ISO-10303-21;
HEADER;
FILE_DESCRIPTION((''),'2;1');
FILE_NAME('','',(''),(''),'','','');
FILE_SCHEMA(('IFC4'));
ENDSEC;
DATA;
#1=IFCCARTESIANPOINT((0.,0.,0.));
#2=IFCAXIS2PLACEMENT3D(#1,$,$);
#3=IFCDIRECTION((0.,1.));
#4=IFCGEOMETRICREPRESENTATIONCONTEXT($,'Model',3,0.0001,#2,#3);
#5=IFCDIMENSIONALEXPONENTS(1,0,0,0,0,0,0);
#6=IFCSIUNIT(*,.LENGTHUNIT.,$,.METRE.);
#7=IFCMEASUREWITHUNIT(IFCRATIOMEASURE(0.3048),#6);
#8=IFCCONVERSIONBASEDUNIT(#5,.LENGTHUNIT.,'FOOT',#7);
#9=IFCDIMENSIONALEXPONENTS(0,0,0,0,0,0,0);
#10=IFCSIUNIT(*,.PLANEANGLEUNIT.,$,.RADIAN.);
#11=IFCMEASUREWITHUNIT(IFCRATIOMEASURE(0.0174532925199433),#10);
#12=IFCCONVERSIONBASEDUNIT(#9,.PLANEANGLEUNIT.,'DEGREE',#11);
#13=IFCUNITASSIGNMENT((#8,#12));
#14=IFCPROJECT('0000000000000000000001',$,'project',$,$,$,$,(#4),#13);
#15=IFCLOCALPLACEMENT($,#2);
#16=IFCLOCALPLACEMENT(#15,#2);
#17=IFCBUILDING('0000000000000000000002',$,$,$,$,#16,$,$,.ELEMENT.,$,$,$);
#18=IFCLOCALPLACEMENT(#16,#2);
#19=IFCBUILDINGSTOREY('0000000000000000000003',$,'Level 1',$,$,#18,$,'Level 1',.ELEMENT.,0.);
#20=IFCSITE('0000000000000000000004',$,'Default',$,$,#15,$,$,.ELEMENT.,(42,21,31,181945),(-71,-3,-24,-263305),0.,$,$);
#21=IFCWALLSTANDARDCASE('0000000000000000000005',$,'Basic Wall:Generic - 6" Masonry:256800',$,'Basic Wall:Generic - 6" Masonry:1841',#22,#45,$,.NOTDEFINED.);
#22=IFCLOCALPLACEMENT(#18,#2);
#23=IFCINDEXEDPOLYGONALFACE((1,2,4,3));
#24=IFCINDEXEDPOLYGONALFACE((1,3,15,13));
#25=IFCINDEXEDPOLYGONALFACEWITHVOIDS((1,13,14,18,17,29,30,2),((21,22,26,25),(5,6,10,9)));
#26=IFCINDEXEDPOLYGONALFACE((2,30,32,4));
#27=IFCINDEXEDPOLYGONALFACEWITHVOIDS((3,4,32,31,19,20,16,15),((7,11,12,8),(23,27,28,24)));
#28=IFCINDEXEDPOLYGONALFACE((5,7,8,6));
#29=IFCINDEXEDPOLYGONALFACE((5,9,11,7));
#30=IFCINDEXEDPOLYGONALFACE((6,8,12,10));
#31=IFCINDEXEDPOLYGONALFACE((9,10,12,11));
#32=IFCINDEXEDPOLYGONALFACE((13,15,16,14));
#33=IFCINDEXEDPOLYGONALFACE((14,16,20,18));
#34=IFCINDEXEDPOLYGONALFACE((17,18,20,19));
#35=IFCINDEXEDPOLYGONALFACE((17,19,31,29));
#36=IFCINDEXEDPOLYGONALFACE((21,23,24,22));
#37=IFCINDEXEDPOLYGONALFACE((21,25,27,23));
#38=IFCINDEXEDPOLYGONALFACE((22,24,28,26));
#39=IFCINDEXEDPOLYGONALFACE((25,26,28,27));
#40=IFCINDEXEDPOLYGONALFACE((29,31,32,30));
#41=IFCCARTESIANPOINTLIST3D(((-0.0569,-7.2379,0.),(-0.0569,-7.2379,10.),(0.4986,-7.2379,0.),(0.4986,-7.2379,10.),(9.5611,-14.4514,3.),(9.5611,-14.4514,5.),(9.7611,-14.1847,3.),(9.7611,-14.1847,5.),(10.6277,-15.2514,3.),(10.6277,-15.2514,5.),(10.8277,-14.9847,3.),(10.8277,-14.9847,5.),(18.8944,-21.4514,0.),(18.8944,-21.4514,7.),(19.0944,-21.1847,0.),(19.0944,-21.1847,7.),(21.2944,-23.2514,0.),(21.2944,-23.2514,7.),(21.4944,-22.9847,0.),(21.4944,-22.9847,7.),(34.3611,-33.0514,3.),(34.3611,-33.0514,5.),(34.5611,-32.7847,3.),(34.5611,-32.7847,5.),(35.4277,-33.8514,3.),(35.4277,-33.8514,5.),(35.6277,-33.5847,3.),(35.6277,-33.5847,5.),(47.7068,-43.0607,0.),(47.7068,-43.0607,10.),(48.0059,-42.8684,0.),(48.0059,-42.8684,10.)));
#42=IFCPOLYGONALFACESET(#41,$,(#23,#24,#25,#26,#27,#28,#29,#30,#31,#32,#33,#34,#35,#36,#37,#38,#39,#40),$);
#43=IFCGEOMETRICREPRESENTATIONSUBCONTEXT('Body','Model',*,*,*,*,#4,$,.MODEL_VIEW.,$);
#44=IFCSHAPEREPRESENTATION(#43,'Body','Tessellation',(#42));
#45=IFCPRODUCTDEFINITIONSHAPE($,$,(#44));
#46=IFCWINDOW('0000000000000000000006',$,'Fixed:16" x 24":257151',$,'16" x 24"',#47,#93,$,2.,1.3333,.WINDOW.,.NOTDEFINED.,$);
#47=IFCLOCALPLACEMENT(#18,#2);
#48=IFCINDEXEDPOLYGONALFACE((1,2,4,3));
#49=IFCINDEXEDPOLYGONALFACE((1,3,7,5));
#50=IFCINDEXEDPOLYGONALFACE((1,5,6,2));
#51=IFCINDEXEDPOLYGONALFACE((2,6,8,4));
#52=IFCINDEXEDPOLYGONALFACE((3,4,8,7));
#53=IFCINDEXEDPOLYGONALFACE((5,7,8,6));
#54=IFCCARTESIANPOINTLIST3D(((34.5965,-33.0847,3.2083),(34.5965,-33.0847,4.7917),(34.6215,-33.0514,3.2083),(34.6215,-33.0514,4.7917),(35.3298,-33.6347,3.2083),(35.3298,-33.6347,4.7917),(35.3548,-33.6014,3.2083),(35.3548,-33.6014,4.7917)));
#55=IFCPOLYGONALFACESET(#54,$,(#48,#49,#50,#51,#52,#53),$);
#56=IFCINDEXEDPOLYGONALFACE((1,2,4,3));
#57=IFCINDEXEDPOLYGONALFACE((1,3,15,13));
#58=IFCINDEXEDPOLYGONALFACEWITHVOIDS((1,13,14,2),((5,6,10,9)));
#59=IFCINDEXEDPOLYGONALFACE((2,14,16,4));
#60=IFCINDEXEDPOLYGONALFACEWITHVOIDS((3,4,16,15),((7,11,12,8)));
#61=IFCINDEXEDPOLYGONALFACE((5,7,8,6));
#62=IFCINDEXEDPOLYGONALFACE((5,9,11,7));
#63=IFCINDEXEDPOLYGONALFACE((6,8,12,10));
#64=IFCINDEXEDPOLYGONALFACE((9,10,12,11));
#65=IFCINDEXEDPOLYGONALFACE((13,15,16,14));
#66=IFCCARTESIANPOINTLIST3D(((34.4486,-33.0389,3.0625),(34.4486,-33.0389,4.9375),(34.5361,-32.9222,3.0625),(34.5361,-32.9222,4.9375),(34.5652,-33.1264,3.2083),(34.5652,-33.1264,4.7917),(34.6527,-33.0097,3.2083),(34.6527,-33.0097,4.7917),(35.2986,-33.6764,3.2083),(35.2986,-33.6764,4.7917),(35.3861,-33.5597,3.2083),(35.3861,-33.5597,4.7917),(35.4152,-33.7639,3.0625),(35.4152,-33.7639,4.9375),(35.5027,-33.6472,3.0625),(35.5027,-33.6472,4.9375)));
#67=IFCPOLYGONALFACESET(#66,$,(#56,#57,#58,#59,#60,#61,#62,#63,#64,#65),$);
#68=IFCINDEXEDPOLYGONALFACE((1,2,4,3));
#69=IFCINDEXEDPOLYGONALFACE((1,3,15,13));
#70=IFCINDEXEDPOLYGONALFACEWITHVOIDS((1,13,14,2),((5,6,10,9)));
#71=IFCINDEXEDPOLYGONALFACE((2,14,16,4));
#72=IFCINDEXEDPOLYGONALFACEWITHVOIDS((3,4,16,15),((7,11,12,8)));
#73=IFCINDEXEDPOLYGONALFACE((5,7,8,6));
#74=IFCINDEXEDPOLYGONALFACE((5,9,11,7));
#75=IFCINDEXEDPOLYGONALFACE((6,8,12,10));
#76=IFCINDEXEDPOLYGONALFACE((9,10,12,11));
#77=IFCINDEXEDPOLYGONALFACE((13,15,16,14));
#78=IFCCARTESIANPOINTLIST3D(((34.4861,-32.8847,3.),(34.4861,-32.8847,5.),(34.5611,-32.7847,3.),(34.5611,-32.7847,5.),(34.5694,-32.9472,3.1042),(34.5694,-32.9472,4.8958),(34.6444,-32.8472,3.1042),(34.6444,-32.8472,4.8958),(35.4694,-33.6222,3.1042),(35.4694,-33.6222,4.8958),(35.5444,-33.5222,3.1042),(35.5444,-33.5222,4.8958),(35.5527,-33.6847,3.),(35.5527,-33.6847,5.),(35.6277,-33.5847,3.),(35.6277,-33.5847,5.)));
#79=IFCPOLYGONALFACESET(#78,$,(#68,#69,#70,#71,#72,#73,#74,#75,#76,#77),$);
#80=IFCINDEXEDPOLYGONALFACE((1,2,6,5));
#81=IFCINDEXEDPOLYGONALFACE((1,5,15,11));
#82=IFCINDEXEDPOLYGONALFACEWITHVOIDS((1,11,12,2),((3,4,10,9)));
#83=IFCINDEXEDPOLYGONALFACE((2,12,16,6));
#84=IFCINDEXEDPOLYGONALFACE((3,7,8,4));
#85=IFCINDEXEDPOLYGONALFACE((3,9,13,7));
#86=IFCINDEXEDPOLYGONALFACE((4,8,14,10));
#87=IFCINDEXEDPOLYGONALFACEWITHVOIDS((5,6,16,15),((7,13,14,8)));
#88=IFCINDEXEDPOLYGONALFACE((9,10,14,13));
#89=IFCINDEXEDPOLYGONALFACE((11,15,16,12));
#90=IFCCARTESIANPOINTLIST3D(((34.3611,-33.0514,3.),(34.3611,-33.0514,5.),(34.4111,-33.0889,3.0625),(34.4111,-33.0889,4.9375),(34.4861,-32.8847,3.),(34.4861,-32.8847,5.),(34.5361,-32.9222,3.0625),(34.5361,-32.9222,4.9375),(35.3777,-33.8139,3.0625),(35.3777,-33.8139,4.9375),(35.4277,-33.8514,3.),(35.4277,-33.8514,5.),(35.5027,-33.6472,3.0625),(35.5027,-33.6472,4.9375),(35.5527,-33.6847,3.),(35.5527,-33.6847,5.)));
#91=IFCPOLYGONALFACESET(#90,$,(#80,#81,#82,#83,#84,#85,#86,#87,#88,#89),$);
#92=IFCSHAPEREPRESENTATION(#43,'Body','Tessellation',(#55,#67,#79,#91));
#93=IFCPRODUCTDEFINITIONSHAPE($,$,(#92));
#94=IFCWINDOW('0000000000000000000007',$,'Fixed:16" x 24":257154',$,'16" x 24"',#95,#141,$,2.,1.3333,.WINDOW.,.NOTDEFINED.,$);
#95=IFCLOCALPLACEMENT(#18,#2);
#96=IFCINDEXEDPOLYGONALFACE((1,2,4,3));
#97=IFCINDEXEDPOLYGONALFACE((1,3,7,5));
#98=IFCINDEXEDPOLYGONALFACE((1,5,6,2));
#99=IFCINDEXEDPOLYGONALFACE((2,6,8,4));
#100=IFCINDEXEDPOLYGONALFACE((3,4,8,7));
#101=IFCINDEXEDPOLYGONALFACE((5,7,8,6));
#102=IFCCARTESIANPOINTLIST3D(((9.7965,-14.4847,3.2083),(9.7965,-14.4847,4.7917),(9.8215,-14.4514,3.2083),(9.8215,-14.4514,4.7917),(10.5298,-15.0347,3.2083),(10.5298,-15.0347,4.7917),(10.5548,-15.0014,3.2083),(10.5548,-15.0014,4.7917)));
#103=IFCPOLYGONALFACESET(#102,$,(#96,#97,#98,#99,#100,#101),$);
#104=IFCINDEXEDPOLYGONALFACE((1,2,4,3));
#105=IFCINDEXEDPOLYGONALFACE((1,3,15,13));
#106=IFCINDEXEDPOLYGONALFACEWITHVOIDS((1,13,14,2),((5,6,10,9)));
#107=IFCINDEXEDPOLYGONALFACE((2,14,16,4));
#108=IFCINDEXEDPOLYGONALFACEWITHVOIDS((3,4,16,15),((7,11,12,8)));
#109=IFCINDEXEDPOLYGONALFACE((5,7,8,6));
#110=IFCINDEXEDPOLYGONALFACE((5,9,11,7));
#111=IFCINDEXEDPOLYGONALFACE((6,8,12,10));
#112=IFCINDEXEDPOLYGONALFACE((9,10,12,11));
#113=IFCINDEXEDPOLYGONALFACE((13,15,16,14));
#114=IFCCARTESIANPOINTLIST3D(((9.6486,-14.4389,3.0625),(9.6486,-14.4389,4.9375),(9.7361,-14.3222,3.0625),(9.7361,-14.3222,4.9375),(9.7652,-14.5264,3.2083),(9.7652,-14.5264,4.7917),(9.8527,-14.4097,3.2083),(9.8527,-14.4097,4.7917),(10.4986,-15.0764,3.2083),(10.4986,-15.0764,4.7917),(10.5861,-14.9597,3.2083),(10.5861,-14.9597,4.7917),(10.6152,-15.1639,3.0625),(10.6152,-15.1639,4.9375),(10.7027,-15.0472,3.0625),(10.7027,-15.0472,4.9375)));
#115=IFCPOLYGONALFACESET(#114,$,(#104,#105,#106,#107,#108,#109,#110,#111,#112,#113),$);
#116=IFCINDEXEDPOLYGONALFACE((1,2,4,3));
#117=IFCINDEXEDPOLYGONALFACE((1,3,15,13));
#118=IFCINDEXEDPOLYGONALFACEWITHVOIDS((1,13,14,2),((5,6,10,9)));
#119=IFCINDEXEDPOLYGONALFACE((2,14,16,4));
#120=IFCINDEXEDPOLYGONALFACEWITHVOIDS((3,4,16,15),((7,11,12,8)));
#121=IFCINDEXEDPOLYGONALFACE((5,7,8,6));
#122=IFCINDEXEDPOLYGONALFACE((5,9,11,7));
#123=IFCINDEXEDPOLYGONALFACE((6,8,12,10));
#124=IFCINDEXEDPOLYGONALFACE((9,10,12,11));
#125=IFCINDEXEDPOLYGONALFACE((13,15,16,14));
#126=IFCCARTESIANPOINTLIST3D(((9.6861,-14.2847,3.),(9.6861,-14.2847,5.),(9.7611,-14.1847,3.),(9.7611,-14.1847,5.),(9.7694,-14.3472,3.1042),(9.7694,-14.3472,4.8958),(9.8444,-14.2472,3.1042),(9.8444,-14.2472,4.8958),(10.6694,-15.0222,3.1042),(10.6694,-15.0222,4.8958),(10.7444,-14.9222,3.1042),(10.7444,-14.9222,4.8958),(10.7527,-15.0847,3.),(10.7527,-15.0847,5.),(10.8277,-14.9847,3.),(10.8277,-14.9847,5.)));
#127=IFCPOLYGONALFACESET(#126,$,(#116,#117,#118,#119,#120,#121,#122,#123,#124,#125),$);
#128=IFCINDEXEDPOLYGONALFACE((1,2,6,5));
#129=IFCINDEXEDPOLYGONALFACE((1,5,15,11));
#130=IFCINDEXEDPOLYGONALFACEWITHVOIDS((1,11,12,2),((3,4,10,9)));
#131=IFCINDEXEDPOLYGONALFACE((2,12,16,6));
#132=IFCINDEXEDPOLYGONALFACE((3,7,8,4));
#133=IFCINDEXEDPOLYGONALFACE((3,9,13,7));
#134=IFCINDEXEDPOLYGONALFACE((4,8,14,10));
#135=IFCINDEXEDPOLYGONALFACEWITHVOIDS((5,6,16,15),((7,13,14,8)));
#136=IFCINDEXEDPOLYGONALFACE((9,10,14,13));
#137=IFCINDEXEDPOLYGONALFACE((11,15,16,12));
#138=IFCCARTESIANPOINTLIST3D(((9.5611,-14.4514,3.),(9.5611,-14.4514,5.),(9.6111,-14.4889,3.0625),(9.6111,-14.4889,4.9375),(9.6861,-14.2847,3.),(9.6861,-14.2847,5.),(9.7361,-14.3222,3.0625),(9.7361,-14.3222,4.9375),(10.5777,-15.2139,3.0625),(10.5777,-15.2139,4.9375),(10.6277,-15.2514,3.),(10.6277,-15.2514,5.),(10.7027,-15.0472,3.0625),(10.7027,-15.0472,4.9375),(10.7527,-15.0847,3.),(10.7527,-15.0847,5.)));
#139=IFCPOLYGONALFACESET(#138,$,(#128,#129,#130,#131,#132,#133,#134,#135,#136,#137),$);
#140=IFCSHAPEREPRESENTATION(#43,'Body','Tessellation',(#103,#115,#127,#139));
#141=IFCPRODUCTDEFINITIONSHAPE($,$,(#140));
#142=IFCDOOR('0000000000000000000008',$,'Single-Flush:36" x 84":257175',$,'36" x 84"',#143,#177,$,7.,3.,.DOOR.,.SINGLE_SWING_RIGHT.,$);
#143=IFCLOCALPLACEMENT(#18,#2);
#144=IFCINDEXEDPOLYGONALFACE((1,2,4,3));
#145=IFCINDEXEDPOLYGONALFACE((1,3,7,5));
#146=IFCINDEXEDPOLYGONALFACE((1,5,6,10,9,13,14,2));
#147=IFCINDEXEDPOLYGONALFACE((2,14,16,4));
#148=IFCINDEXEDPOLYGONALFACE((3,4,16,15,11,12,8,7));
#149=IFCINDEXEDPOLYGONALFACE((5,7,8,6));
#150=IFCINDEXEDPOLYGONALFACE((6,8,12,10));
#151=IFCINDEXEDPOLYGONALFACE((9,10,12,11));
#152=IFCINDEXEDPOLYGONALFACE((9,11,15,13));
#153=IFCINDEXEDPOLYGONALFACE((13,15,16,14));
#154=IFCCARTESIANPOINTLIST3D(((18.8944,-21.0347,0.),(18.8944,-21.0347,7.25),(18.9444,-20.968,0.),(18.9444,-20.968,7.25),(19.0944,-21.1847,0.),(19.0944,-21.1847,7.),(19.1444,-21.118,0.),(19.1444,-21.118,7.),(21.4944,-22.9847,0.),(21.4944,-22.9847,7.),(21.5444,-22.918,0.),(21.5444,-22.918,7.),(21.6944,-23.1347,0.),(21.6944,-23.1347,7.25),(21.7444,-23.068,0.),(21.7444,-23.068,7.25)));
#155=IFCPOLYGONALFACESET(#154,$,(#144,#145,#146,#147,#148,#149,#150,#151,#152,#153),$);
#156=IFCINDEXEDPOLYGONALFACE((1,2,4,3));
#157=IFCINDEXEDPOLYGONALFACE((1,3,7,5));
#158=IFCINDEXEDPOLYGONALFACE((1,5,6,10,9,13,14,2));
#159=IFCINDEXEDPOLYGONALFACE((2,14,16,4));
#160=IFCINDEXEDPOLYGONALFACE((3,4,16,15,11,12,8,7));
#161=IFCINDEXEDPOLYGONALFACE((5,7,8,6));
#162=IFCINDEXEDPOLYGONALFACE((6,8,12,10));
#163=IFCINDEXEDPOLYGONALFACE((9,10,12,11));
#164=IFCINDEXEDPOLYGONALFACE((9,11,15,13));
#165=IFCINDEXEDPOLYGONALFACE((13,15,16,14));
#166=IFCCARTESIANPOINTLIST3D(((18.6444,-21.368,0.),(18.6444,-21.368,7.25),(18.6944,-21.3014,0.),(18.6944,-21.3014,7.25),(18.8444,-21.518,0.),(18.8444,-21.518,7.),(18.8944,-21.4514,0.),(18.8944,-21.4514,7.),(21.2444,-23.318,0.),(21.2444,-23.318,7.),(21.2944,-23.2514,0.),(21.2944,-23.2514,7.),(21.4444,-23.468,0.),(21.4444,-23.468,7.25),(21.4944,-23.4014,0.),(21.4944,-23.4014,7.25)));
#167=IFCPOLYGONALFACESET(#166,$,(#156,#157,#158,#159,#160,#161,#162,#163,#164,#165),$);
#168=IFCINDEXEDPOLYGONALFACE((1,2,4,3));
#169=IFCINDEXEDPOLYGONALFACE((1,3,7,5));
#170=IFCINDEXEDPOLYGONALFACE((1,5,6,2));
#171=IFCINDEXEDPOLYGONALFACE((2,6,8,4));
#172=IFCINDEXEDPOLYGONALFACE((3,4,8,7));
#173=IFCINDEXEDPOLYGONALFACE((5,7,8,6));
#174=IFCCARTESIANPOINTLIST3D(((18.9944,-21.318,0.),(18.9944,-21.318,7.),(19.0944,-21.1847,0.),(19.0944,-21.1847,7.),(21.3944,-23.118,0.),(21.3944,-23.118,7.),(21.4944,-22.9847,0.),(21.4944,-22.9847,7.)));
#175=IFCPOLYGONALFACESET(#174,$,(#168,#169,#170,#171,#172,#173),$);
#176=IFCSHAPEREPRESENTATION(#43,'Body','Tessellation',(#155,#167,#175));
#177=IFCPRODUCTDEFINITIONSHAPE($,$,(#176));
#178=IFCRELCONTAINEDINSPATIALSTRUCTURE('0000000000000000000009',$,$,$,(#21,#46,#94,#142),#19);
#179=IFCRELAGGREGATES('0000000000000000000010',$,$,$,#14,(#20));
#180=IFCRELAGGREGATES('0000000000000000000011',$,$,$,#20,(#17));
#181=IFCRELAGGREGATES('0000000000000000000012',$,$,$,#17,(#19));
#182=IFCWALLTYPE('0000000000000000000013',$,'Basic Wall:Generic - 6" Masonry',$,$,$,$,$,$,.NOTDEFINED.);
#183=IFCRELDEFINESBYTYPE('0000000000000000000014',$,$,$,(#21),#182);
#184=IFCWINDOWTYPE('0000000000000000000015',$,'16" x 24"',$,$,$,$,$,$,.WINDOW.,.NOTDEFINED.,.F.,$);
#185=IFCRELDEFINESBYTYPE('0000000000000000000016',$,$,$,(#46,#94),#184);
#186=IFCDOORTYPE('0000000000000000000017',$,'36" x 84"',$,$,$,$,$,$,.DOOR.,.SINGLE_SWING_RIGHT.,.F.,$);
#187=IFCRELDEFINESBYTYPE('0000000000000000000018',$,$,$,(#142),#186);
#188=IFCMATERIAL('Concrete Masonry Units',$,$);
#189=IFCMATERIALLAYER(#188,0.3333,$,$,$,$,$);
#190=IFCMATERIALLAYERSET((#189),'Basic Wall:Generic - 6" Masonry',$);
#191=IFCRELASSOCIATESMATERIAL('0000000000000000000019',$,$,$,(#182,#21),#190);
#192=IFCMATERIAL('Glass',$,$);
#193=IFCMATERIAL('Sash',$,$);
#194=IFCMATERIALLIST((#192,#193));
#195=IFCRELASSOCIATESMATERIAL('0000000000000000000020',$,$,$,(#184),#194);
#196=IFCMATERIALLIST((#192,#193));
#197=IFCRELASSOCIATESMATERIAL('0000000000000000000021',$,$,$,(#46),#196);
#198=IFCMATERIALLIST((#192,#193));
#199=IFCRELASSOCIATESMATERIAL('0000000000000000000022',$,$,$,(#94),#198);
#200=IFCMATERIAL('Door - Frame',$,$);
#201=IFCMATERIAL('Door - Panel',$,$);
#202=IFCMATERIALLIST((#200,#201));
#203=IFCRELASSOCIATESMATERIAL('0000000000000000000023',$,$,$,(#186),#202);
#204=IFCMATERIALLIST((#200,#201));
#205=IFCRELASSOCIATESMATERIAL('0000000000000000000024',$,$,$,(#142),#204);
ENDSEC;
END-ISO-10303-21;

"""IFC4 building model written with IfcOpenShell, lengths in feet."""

from ifc_helpers import new_model, entity, si_unit, converted_unit, direction, frame, frame_2d, origin, origin_2d_with_axis, place, context, subcontext, project, spatial, polyline, rectangle, outline, extrude, source, transform, mapped, material, material_list, layer, layer_set, layer_usage, type_object, type_shapes, element, fill, save


model = new_model("IFC4")

# Units and contexts
model_context = context("Model", 3, precision=0.0001, world=origin(), true_north=direction((0.0, 1.0)))
body_context = subcontext(model_context, "Body", "Model", "MODEL_VIEW")
ifc_project = project(units=[converted_unit("LENGTHUNIT", "FOOT", entity("IfcRatioMeasure", 0.3048), si_unit("LENGTHUNIT", "METRE"), dimensions=[1, 0, 0, 0, 0, 0, 0]), converted_unit("PLANEANGLEUNIT", "DEGREE", entity("IfcRatioMeasure", 0.0174532925199433), si_unit("PLANEANGLEUNIT", "RADIAN"), dimensions=[0, 0, 0, 0, 0, 0, 0])], contexts=[model_context])

# Site, building, storey
site_placement = place(None, origin())
site = spatial("IfcSite", under=ifc_project, at=site_placement, Name="Default", CompositionType="ELEMENT", RefLatitude=(42, 21, 31, 181945), RefLongitude=(-71, -3, -24, -263305), RefElevation=0.0)
building_placement = place(site_placement, origin())
building = spatial("IfcBuilding", under=site, at=building_placement, CompositionType="ELEMENT")
storey_placement = place(building_placement, origin())
storey = spatial("IfcBuildingStorey", under=building, at=storey_placement, Name="Level 1", LongName="Level 1", CompositionType="ELEMENT", Elevation=0.0)

# Wall, openings, windows, door
ifc_material_1 = material(Name="Concrete Masonry Units")
ifc_layer = layer(ifc_material_1, 0.3333)
ifc_layer_set = layer_set([ifc_layer], Name="Basic Wall:Generic - 6\" Masonry")
ifc_layer_usage = layer_usage(ifc_layer_set, "AXIS2", "NEGATIVE", 0.1667)
wall_type = type_object("IfcWallType", Name="Basic Wall:Generic - 6\" Masonry", PredefinedType="NOTDEFINED", material=ifc_layer_set)
wall_placement = place(storey_placement, frame((47.9059, -43.0017, 0.0), z_axis=(0.0, 0.0, 1.0), x_axis=(-0.8, 0.6, 0.0)))
wall = element("IfcWallStandardCase", 1, at=wall_placement, inside=storey, type_object=wall_type, material=ifc_layer_usage, Name="Basic Wall:Generic - 6\" Masonry:256800", ObjectType="Basic Wall:Generic - 6\" Masonry:1841", PredefinedType="NOTDEFINED", context=body_context, shape_type="SweptSolid", body=[
    extrude(outline(polyline([(0.0, -0.1667), (59.3842, -0.1667), (59.8286, 0.1667), (0.1239, 0.1667), (0.0, -0.1667)])), origin(), (0.0, 0.0, 1.0), 10.0),
])
opening_1_placement = place(wall_placement, frame((36.1394, 0.1667, 0.0)))
opening_1 = element("IfcOpeningElement", 2, at=opening_1_placement, cuts=wall, ObjectType="Opening", PredefinedType="OPENING", context=body_context, shape_type="SweptSolid", body=[
    extrude(rectangle(XDim=3.0, YDim=7.0, at=frame_2d((3.5, 1.5), x_axis=(0.0, 1.0))), frame((0.0, 0.0, 0.0), z_axis=(0.0, -1.0, 0.0), x_axis=(0.0, 0.0, 1.0)), (0.0, 0.0, 1.0), 0.3333),
])
opening_2_placement = place(wall_placement, frame((15.4728, -0.1667, 3.0)))
opening_2 = element("IfcOpeningElement", 3, at=opening_2_placement, cuts=wall, ObjectType="Opening", PredefinedType="OPENING", context=body_context, shape_type="SweptSolid", body=[
    extrude(rectangle(XDim=2.0, YDim=1.3333, at=frame_2d((1.0, 0.6667), x_axis=(-1.0, 0.0))), frame((0.0, 0.0, 0.0), z_axis=(0.0, 1.0, 0.0), x_axis=(0.0, 0.0, 1.0)), (0.0, 0.0, 1.0), 0.3333),
])
opening_3_placement = place(wall_placement, frame((46.4728, -0.1667, 3.0)))
opening_3 = element("IfcOpeningElement", 4, at=opening_3_placement, cuts=wall, ObjectType="Opening", PredefinedType="OPENING", context=body_context, shape_type="SweptSolid", body=[
    extrude(rectangle(XDim=2.0, YDim=1.3333, at=frame_2d((1.0, 0.6667), x_axis=(-1.0, 0.0))), frame((0.0, 0.0, 0.0), z_axis=(0.0, 1.0, 0.0), x_axis=(0.0, 0.0, 1.0)), (0.0, 0.0, 1.0), 0.3333),
])
ifc_material_2 = material(Name="Glass")
ifc_material_3 = material(Name="Sash")
ifc_material_list_1 = material_list([ifc_material_2, ifc_material_3])
ifc_material_list_2 = material_list([ifc_material_2, ifc_material_3])
window_type = type_object("IfcWindowType", Name="16\" x 24\"", ParameterTakesPrecedence=False, PartitioningType="NOTDEFINED", PredefinedType="WINDOW", material=ifc_material_list_2)
shared_shape_1 = source(origin(), body_context, "Body", "SweptSolid", [
    extrude(rectangle(XDim=0.0417, YDim=0.9167, at=origin_2d_with_axis()), frame((0.6667, 0.1979, 0.2083), z_axis=(0.0, 0.0, 1.0), x_axis=(0.0, 1.0, 0.0)), (0.0, 0.0, 1.0), 1.5833),
    extrude(outline(polyline([(-0.6042, -0.9375), (0.6042, -0.9375), (0.6042, 0.9375), (-0.6042, 0.9375), (-0.6042, -0.9375)]), holes=[polyline([(-0.4583, -0.7917), (-0.4583, 0.7917), (0.4583, 0.7917), (0.4583, -0.7917), (-0.4583, -0.7917)])]), frame((0.6667, 0.125, 1.0), z_axis=(0.0, 1.0, 0.0), x_axis=(1.0, 0.0, 0.0)), (0.0, 0.0, 1.0), 0.1458),
    extrude(outline(polyline([(-0.6667, -1.0), (0.6667, -1.0), (0.6667, 1.0), (-0.6667, 1.0), (-0.6667, -1.0)]), holes=[polyline([(-0.5625, -0.8958), (-0.5625, 0.8958), (0.5625, 0.8958), (0.5625, -0.8958), (-0.5625, -0.8958)])]), frame((0.6667, 0.0, 1.0), z_axis=(0.0, 1.0, 0.0), x_axis=(1.0, 0.0, 0.0)), (0.0, 0.0, 1.0), 0.125),
    extrude(outline(polyline([(-1.0, -0.6667), (1.0, -0.6667), (1.0, 0.6667), (-1.0, 0.6667), (-1.0, -0.6667)]), holes=[polyline([(-0.9375, -0.6042), (-0.9375, 0.6042), (0.9375, 0.6042), (0.9375, -0.6042), (-0.9375, -0.6042)])]), frame((0.6667, 0.125, 1.0), z_axis=(0.0, 1.0, 0.0), x_axis=(0.0, 0.0, -1.0)), (0.0, 0.0, 1.0), 0.2083),
])
type_shapes(window_type, [shared_shape_1])
window_1_placement = place(opening_2_placement, origin())
window_1 = element("IfcWindow", 5, at=window_1_placement, inside=storey, type_object=window_type, material=ifc_material_list_1, Name="Fixed:16\" x 24\":257151", ObjectType="16\" x 24\"", OverallHeight=2.0, OverallWidth=1.3333, PartitioningType="NOTDEFINED", PredefinedType="WINDOW", context=body_context, shape_type="MappedRepresentation", body=[
    mapped(shared_shape_1, transform((0.0, 0.0, 0.0), scale=1.0)),
])
fill(opening_2, window_1)
ifc_material_list_3 = material_list([ifc_material_2, ifc_material_3])
window_2_placement = place(opening_3_placement, origin())
window_2 = element("IfcWindow", 6, at=window_2_placement, inside=storey, type_object=window_type, material=ifc_material_list_3, Name="Fixed:16\" x 24\":257154", ObjectType="16\" x 24\"", OverallHeight=2.0, OverallWidth=1.3333, PartitioningType="NOTDEFINED", PredefinedType="WINDOW", context=body_context, shape_type="MappedRepresentation", body=[
    mapped(shared_shape_1, transform((0.0, 0.0, 0.0), scale=1.0)),
])
fill(opening_3, window_2)
ifc_material_4 = material(Name="Door - Frame")
ifc_material_5 = material(Name="Door - Panel")
ifc_material_list_4 = material_list([ifc_material_4, ifc_material_5])
ifc_material_list_5 = material_list([ifc_material_4, ifc_material_5])
door_type = type_object("IfcDoorType", Name="36\" x 84\"", OperationType="SINGLE_SWING_RIGHT", ParameterTakesPrecedence=False, PredefinedType="DOOR", material=ifc_material_list_5)
shared_shape_2 = source(origin(), body_context, "Body", "SweptSolid", [
    extrude(outline(polyline([(-1.75, -3.6875), (1.75, -3.6875), (1.75, 3.5625), (1.5, 3.5625), (1.5, -3.4375), (-1.5, -3.4375), (-1.5, 3.5625), (-1.75, 3.5625), (-1.75, -3.6875)])), frame((1.5, 0.3333, 3.5625), z_axis=(0.0, 1.0, 0.0), x_axis=(1.0, 0.0, 0.0)), (0.0, 0.0, 1.0), 0.0833),
    extrude(outline(polyline([(-3.6875, -1.75), (3.5625, -1.75), (3.5625, -1.5), (-3.4375, -1.5), (-3.4375, 1.5), (3.5625, 1.5), (3.5625, 1.75), (-3.6875, 1.75), (-3.6875, -1.75)])), frame((1.5, -0.0833, 3.5625), z_axis=(0.0, 1.0, 0.0), x_axis=(0.0, 0.0, -1.0)), (0.0, 0.0, 1.0), 0.0833),
    extrude(rectangle(XDim=0.1667, YDim=3.0, at=frame_2d((0.0, 0.0), x_axis=(1.0, 0.0))), frame((1.5, 0.25, 0.0), z_axis=(0.0, 0.0, 1.0), x_axis=(0.0, 1.0, 0.0)), (0.0, 0.0, 1.0), 7.0),
])
type_shapes(door_type, [shared_shape_2])
door_placement = place(opening_1_placement, frame((0.0, 0.0, 0.0), z_axis=(0.0, 0.0, 1.0), x_axis=(-1.0, 0.0, 0.0)))
door = element("IfcDoor", 7, at=door_placement, inside=storey, type_object=door_type, material=ifc_material_list_4, Name="Single-Flush:36\" x 84\":257175", ObjectType="36\" x 84\"", OperationType="SINGLE_SWING_RIGHT", OverallHeight=7.0, OverallWidth=3.0, PredefinedType="DOOR", context=body_context, shape_type="MappedRepresentation", body=[
    mapped(shared_shape_2, transform((0.0, 0.0, 0.0), scale=1.0)),
])
fill(opening_1, door)

save(model, "model.ifc")
